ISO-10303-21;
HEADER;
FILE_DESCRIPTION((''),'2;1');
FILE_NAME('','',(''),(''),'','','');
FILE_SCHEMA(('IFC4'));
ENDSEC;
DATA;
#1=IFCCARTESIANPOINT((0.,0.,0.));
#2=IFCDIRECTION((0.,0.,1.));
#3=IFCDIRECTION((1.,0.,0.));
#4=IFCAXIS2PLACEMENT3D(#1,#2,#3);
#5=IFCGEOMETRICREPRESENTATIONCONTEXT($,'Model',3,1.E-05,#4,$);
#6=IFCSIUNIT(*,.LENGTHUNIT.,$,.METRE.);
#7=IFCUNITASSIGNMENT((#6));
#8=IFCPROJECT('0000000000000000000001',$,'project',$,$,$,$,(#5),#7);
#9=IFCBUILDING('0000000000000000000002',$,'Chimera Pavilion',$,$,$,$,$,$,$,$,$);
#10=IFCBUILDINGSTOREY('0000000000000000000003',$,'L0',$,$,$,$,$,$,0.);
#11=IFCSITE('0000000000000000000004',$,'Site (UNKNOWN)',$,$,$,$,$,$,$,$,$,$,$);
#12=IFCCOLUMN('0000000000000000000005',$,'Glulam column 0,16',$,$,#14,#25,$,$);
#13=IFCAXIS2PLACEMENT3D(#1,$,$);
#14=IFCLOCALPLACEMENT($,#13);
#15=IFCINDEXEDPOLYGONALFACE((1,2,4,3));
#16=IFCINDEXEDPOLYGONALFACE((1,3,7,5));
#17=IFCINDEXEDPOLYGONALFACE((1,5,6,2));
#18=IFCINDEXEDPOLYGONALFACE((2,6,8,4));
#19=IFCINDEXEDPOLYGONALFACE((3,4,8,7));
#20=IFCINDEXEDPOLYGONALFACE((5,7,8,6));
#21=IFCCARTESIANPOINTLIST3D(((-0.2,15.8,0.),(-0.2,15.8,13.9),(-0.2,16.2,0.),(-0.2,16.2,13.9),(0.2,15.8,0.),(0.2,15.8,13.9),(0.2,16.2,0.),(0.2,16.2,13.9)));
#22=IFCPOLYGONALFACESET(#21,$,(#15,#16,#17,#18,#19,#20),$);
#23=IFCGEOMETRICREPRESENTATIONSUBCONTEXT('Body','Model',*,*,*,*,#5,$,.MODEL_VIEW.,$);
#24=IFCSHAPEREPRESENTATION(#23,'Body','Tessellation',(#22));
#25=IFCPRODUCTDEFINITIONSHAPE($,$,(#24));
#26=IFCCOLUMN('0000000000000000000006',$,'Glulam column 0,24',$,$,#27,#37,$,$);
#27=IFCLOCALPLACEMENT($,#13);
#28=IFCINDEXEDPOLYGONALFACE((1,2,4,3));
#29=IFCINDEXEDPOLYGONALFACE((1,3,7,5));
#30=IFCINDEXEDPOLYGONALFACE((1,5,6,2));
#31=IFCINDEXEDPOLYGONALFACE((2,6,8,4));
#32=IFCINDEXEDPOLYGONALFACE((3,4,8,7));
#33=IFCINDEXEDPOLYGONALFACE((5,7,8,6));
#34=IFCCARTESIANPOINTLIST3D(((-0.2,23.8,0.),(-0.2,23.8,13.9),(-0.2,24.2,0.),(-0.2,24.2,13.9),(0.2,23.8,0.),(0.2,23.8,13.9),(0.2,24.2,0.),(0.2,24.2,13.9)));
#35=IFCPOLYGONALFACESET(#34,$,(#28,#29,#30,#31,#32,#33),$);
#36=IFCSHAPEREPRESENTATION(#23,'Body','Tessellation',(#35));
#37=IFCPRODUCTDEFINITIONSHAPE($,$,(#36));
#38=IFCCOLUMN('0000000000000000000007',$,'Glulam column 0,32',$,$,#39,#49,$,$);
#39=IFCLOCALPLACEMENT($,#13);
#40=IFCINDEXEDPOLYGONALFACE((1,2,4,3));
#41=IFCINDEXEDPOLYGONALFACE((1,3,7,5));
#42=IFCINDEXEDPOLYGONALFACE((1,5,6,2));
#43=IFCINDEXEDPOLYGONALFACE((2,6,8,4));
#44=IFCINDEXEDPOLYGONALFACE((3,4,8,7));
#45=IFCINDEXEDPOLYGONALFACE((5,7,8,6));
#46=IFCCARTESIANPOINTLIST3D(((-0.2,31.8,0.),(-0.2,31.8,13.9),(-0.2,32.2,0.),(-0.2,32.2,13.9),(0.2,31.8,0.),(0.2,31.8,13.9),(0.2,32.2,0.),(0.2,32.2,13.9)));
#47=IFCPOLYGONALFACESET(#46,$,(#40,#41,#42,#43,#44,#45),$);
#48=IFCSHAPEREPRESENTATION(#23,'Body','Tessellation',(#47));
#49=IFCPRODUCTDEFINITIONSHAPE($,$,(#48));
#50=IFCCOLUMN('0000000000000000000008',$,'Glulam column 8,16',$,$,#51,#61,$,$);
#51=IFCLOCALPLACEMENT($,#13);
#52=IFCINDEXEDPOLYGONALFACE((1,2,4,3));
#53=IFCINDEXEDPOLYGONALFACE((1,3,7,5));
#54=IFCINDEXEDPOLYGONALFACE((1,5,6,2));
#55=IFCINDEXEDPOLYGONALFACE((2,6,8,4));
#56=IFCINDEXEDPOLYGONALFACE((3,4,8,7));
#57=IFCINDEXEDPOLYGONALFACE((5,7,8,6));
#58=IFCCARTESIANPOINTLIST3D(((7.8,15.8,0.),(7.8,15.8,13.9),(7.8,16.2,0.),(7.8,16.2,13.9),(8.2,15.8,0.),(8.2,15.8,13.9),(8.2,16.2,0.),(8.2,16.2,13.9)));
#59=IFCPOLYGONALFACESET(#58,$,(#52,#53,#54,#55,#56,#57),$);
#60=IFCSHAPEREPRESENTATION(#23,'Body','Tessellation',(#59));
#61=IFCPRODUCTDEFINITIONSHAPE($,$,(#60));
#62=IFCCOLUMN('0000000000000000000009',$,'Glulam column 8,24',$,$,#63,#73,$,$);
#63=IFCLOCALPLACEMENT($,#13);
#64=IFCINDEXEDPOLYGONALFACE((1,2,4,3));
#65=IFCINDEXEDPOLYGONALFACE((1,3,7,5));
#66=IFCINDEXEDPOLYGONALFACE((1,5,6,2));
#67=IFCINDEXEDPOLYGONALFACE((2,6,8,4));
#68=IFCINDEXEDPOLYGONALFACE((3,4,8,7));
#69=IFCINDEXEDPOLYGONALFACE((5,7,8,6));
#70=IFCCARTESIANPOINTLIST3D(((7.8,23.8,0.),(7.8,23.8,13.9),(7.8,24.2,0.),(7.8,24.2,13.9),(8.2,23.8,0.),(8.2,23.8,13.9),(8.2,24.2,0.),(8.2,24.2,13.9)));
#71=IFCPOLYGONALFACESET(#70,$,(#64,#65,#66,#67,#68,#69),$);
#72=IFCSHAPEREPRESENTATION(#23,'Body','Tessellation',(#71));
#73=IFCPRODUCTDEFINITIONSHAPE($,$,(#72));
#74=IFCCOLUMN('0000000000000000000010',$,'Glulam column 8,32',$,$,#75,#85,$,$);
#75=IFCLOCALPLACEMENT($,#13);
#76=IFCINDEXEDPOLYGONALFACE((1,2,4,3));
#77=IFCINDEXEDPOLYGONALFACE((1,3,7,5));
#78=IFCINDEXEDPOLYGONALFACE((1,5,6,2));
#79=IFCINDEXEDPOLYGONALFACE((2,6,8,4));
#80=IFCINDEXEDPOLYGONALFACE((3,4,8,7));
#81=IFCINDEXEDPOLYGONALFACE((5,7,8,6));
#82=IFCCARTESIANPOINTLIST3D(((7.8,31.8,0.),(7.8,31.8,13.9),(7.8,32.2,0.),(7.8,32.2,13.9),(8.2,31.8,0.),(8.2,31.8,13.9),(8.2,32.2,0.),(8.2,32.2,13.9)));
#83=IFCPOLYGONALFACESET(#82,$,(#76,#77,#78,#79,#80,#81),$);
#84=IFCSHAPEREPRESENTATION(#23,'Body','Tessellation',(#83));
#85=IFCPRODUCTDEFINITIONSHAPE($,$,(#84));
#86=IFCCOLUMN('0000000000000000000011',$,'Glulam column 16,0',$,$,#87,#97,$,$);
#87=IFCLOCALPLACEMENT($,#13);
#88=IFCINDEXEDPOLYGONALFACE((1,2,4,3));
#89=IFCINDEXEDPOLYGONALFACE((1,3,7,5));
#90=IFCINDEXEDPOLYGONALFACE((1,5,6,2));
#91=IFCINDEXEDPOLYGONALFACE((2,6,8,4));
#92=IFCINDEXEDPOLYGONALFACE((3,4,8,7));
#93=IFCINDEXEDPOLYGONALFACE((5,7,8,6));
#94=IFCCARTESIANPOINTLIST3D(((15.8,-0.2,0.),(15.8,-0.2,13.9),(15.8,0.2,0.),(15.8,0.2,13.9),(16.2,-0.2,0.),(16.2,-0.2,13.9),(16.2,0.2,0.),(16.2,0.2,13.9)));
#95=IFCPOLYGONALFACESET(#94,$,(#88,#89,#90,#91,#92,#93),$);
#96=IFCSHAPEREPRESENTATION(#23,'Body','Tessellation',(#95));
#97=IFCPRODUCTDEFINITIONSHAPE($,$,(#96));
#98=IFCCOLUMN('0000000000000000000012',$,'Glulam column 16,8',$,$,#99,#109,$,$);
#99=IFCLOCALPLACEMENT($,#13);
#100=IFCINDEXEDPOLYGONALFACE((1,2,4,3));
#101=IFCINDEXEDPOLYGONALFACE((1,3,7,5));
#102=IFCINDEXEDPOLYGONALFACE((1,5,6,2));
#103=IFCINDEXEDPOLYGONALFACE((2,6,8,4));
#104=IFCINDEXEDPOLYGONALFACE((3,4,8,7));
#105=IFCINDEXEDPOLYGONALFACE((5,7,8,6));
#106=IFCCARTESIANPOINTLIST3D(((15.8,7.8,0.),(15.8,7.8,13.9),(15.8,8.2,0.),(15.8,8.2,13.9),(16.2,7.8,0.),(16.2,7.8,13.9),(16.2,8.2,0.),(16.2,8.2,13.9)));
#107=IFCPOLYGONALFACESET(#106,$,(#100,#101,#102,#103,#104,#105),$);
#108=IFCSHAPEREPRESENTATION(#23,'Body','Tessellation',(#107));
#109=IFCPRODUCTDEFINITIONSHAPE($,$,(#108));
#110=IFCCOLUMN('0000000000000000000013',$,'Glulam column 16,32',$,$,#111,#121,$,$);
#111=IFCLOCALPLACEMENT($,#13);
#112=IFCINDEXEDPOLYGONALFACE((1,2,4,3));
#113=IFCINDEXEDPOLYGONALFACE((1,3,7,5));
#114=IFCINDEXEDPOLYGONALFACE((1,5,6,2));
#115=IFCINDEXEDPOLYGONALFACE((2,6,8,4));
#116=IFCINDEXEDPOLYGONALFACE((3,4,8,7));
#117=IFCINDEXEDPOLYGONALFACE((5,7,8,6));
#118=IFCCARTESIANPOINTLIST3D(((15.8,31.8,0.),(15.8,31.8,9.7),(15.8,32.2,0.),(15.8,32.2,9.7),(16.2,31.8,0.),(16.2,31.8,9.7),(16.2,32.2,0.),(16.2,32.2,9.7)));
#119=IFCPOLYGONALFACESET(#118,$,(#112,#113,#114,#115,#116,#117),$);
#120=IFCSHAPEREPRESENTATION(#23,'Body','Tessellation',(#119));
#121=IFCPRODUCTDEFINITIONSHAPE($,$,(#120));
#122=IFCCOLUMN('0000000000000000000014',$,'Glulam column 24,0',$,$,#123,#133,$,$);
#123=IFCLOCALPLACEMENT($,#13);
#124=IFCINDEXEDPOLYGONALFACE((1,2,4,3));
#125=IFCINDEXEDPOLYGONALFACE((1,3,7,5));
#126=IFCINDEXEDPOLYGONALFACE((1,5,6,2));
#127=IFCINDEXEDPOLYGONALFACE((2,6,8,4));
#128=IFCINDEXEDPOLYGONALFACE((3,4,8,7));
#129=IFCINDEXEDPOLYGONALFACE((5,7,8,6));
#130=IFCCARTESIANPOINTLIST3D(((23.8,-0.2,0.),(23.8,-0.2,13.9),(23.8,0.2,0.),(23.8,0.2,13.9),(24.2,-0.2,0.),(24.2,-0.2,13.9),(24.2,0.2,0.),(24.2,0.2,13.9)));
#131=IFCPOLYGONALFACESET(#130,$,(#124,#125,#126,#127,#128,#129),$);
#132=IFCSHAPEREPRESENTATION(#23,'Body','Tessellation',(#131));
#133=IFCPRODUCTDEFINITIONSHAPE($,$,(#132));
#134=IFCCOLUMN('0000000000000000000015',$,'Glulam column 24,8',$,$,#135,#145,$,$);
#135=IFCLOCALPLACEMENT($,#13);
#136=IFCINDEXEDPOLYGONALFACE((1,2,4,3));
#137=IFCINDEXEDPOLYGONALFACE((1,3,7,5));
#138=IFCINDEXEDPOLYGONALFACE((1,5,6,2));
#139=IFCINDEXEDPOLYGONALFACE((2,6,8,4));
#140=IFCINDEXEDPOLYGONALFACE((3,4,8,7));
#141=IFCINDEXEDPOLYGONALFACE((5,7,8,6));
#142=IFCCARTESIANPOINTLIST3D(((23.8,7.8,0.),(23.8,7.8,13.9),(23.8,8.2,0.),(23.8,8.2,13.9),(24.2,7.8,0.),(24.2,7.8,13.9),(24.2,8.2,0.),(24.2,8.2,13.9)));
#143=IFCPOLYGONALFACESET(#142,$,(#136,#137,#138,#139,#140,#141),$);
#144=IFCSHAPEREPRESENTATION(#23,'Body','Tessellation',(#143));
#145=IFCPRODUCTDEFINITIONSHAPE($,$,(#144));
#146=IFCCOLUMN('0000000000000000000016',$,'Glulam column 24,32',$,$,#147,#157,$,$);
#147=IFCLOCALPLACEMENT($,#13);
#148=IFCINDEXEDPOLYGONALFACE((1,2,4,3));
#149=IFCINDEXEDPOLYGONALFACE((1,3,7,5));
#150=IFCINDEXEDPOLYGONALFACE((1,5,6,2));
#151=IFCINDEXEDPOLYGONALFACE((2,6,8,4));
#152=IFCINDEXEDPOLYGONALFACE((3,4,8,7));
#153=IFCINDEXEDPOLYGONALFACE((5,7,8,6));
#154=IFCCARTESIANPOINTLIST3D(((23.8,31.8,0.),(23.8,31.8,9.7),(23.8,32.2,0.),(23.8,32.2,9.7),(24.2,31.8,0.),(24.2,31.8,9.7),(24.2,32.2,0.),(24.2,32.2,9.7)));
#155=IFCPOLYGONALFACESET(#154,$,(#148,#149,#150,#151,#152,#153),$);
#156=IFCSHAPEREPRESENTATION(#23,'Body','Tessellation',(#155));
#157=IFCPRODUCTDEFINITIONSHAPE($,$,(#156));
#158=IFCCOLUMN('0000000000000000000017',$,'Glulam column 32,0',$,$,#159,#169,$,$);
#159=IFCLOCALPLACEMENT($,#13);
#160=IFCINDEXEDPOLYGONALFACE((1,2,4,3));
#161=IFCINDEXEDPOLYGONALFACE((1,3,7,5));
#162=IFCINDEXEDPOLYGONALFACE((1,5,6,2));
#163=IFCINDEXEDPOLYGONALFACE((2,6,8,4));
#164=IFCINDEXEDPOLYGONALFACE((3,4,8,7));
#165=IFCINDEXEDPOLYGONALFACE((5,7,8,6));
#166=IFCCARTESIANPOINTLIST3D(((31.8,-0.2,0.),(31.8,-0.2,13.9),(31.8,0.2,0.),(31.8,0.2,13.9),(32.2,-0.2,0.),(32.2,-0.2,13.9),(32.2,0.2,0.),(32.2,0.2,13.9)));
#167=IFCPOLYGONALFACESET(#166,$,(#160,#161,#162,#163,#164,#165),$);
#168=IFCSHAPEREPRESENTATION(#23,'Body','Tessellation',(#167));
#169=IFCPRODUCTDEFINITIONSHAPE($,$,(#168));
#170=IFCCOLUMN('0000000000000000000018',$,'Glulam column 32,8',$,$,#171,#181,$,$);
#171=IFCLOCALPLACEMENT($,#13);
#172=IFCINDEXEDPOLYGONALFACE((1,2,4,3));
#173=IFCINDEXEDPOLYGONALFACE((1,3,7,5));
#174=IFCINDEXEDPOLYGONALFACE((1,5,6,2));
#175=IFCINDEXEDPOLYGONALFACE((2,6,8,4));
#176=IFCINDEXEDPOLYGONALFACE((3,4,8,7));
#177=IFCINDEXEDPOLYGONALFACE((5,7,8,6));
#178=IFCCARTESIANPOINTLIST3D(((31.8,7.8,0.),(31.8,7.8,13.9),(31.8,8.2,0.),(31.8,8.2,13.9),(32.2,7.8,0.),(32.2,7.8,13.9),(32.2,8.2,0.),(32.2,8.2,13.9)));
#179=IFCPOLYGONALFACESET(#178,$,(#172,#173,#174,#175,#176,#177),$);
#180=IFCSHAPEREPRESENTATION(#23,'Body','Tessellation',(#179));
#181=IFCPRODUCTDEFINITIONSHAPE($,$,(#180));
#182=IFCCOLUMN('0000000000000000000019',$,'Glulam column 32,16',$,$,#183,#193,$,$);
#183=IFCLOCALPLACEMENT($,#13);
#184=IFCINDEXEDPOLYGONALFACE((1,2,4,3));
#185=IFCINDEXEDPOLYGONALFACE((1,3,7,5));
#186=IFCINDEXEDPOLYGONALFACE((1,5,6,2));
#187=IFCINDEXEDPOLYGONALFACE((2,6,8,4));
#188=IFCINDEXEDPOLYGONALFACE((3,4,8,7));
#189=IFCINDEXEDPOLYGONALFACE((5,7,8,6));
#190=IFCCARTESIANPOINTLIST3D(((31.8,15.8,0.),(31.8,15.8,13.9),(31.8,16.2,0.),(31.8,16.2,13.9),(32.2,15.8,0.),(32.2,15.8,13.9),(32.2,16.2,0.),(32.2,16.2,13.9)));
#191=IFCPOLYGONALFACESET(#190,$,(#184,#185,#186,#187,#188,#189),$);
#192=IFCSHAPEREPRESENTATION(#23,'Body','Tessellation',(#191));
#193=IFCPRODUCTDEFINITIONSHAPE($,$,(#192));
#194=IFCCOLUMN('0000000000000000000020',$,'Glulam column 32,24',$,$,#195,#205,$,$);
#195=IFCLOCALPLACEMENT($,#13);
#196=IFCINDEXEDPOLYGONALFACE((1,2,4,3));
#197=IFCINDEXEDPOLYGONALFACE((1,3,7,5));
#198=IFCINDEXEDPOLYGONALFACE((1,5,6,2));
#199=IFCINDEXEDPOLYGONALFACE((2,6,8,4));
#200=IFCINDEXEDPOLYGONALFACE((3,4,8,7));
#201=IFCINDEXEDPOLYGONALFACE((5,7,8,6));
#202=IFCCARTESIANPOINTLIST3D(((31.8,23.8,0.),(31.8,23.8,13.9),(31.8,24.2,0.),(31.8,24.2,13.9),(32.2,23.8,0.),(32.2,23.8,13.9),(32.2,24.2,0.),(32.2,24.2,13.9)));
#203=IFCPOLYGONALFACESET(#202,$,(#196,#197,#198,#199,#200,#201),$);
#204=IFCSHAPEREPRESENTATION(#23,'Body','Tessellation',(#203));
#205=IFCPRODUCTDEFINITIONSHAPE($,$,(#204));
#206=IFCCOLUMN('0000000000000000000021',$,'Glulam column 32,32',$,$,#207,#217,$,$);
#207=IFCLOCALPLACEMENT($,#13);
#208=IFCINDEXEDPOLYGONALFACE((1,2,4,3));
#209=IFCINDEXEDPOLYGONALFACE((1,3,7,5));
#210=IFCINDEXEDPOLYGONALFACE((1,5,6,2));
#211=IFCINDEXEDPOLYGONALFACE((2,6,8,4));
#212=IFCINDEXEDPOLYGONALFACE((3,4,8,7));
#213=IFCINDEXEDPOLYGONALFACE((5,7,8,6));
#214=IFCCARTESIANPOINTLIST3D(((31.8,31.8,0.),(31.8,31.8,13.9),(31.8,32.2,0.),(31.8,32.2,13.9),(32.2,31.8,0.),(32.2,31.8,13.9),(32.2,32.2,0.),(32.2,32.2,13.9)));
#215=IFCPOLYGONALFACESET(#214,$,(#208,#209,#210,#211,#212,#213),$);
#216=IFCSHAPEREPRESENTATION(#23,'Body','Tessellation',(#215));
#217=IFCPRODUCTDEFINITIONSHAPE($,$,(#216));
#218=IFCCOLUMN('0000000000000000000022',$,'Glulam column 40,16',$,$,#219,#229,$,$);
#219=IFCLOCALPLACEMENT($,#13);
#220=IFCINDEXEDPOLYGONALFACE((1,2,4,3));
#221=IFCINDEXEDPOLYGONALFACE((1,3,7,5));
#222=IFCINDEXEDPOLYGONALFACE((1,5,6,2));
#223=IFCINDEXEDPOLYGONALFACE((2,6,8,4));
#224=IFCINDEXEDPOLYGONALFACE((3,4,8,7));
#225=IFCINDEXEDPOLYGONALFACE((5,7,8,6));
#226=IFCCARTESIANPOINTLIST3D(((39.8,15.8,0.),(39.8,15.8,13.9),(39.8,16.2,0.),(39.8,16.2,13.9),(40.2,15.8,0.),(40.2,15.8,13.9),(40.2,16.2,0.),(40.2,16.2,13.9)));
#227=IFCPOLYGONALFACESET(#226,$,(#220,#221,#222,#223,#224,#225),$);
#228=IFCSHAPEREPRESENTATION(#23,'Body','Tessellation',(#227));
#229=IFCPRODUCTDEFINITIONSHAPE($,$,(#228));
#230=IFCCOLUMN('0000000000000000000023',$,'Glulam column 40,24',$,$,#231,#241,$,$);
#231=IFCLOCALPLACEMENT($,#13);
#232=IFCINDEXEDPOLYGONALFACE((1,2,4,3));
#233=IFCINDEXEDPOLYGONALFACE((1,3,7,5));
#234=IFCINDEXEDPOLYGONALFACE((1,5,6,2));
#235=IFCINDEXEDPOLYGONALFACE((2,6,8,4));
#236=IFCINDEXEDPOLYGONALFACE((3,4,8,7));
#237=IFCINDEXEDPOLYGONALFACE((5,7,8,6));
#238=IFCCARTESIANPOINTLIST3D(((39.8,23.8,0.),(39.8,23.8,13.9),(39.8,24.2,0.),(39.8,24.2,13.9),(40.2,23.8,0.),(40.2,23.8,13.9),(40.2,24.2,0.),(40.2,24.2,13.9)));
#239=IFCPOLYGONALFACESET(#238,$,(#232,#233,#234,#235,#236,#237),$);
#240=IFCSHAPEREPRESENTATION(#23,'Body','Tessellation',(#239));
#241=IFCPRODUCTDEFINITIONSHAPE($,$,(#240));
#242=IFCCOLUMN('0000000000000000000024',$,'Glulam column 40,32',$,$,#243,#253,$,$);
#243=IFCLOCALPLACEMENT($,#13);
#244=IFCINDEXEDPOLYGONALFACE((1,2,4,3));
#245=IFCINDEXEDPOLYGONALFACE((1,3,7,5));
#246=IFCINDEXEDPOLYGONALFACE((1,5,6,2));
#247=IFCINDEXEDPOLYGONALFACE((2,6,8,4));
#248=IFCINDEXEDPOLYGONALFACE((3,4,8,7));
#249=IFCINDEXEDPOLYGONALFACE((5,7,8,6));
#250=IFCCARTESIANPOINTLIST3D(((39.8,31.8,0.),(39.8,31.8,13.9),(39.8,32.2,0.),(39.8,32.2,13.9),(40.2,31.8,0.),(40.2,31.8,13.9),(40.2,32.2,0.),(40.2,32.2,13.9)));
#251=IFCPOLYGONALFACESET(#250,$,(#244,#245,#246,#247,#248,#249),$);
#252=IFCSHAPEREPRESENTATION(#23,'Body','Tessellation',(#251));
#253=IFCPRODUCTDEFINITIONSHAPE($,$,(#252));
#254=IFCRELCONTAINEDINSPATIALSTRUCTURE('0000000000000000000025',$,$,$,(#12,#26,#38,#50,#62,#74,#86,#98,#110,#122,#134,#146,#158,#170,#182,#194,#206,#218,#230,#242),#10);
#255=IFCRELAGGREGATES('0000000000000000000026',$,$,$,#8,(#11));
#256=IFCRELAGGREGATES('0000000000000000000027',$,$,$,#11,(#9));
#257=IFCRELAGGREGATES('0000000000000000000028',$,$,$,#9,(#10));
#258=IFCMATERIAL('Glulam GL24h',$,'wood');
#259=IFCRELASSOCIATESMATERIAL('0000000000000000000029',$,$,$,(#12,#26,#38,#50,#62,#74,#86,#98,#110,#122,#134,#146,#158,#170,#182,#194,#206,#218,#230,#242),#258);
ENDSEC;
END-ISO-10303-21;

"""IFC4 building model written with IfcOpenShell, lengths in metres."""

from ifc_helpers import new_model, si_unit, frame, origin_with_axes, place, context, subcontext, project, spatial, rectangle, extrude, material, element, save


model = new_model("IFC4")

# Units and contexts
model_context = context("Model", 3, precision=1e-05, world=origin_with_axes())
body_context = subcontext(model_context, "Body", "Model", "MODEL_VIEW")
ifc_project = project(units=[si_unit("LENGTHUNIT", "METRE")], contexts=[model_context])

# Site, building, storey
site = spatial("IfcSite", under=ifc_project, Name="Site (UNKNOWN)")
building = spatial("IfcBuilding", under=site, Name="Chimera Pavilion")
storey = spatial("IfcBuildingStorey", under=building, Name="L0", Elevation=0.0)

# Columns
ifc_material_1 = material(Name="Glulam GL24h", Category="wood")
for number, where, z_axis, x_axis, name in (
    (1, (0.0, 16.0, 0.0), (0.0, 0.0, 1.0), (1.0, 0.0, 0.0), "Glulam column 0,16"),
    (2, (0.0, 24.0, 0.0), (0.0, 0.0, 1.0), (1.0, 0.0, 0.0), "Glulam column 0,24"),
    (3, (0.0, 32.0, 0.0), (0.0, 0.0, 1.0), (1.0, 0.0, 0.0), "Glulam column 0,32"),
    (4, (8.0, 16.0, 0.0), (0.0, 0.0, 1.0), (1.0, 0.0, 0.0), "Glulam column 8,16"),
    (5, (8.0, 24.0, 0.0), (0.0, 0.0, 1.0), (1.0, 0.0, 0.0), "Glulam column 8,24"),
    (6, (8.0, 32.0, 0.0), (0.0, 0.0, 1.0), (1.0, 0.0, 0.0), "Glulam column 8,32"),
    (7, (16.0, 0.0, 0.0), (0.0, 0.0, 1.0), (1.0, 0.0, 0.0), "Glulam column 16,0"),
    (8, (16.0, 8.0, 0.0), (0.0, 0.0, 1.0), (1.0, 0.0, 0.0), "Glulam column 16,8"),
):
    element("IfcColumn", number, at=place(None, frame(where, z_axis=z_axis, x_axis=x_axis)), inside=storey, material=ifc_material_1, Name=name, context=body_context, shape_type="SweptSolid", body=[
        extrude(rectangle(XDim=0.4, YDim=0.4), origin_with_axes(), (0.0, 0.0, 1.0), 13.9),
    ])
column_1_placement = place(None, frame((16.0, 32.0, 0.0), z_axis=(0.0, 0.0, 1.0), x_axis=(1.0, 0.0, 0.0)))
element("IfcColumn", 9, at=column_1_placement, inside=storey, material=ifc_material_1, Name="Glulam column 16,32", context=body_context, shape_type="SweptSolid", body=[
    extrude(rectangle(XDim=0.4, YDim=0.4), origin_with_axes(), (0.0, 0.0, 1.0), 9.7),
])
for number, where, z_axis, x_axis, name in (
    (10, (24.0, 0.0, 0.0), (0.0, 0.0, 1.0), (1.0, 0.0, 0.0), "Glulam column 24,0"),
    (11, (24.0, 8.0, 0.0), (0.0, 0.0, 1.0), (1.0, 0.0, 0.0), "Glulam column 24,8"),
):
    element("IfcColumn", number, at=place(None, frame(where, z_axis=z_axis, x_axis=x_axis)), inside=storey, material=ifc_material_1, Name=name, context=body_context, shape_type="SweptSolid", body=[
        extrude(rectangle(XDim=0.4, YDim=0.4), origin_with_axes(), (0.0, 0.0, 1.0), 13.9),
    ])
column_2_placement = place(None, frame((24.0, 32.0, 0.0), z_axis=(0.0, 0.0, 1.0), x_axis=(1.0, 0.0, 0.0)))
element("IfcColumn", 12, at=column_2_placement, inside=storey, material=ifc_material_1, Name="Glulam column 24,32", context=body_context, shape_type="SweptSolid", body=[
    extrude(rectangle(XDim=0.4, YDim=0.4), origin_with_axes(), (0.0, 0.0, 1.0), 9.7),
])
for number, where, z_axis, x_axis, name in (
    (13, (32.0, 0.0, 0.0), (0.0, 0.0, 1.0), (1.0, 0.0, 0.0), "Glulam column 32,0"),
    (14, (32.0, 8.0, 0.0), (0.0, 0.0, 1.0), (1.0, 0.0, 0.0), "Glulam column 32,8"),
    (15, (32.0, 16.0, 0.0), (0.0, 0.0, 1.0), (1.0, 0.0, 0.0), "Glulam column 32,16"),
    (16, (32.0, 24.0, 0.0), (0.0, 0.0, 1.0), (1.0, 0.0, 0.0), "Glulam column 32,24"),
    (17, (32.0, 32.0, 0.0), (0.0, 0.0, 1.0), (1.0, 0.0, 0.0), "Glulam column 32,32"),
    (18, (40.0, 16.0, 0.0), (0.0, 0.0, 1.0), (1.0, 0.0, 0.0), "Glulam column 40,16"),
    (19, (40.0, 24.0, 0.0), (0.0, 0.0, 1.0), (1.0, 0.0, 0.0), "Glulam column 40,24"),
    (20, (40.0, 32.0, 0.0), (0.0, 0.0, 1.0), (1.0, 0.0, 0.0), "Glulam column 40,32"),
):
    element("IfcColumn", number, at=place(None, frame(where, z_axis=z_axis, x_axis=x_axis)), inside=storey, material=ifc_material_1, Name=name, context=body_context, shape_type="SweptSolid", body=[
        extrude(rectangle(XDim=0.4, YDim=0.4), origin_with_axes(), (0.0, 0.0, 1.0), 13.9),
    ])

save(model, "model.ifc")
